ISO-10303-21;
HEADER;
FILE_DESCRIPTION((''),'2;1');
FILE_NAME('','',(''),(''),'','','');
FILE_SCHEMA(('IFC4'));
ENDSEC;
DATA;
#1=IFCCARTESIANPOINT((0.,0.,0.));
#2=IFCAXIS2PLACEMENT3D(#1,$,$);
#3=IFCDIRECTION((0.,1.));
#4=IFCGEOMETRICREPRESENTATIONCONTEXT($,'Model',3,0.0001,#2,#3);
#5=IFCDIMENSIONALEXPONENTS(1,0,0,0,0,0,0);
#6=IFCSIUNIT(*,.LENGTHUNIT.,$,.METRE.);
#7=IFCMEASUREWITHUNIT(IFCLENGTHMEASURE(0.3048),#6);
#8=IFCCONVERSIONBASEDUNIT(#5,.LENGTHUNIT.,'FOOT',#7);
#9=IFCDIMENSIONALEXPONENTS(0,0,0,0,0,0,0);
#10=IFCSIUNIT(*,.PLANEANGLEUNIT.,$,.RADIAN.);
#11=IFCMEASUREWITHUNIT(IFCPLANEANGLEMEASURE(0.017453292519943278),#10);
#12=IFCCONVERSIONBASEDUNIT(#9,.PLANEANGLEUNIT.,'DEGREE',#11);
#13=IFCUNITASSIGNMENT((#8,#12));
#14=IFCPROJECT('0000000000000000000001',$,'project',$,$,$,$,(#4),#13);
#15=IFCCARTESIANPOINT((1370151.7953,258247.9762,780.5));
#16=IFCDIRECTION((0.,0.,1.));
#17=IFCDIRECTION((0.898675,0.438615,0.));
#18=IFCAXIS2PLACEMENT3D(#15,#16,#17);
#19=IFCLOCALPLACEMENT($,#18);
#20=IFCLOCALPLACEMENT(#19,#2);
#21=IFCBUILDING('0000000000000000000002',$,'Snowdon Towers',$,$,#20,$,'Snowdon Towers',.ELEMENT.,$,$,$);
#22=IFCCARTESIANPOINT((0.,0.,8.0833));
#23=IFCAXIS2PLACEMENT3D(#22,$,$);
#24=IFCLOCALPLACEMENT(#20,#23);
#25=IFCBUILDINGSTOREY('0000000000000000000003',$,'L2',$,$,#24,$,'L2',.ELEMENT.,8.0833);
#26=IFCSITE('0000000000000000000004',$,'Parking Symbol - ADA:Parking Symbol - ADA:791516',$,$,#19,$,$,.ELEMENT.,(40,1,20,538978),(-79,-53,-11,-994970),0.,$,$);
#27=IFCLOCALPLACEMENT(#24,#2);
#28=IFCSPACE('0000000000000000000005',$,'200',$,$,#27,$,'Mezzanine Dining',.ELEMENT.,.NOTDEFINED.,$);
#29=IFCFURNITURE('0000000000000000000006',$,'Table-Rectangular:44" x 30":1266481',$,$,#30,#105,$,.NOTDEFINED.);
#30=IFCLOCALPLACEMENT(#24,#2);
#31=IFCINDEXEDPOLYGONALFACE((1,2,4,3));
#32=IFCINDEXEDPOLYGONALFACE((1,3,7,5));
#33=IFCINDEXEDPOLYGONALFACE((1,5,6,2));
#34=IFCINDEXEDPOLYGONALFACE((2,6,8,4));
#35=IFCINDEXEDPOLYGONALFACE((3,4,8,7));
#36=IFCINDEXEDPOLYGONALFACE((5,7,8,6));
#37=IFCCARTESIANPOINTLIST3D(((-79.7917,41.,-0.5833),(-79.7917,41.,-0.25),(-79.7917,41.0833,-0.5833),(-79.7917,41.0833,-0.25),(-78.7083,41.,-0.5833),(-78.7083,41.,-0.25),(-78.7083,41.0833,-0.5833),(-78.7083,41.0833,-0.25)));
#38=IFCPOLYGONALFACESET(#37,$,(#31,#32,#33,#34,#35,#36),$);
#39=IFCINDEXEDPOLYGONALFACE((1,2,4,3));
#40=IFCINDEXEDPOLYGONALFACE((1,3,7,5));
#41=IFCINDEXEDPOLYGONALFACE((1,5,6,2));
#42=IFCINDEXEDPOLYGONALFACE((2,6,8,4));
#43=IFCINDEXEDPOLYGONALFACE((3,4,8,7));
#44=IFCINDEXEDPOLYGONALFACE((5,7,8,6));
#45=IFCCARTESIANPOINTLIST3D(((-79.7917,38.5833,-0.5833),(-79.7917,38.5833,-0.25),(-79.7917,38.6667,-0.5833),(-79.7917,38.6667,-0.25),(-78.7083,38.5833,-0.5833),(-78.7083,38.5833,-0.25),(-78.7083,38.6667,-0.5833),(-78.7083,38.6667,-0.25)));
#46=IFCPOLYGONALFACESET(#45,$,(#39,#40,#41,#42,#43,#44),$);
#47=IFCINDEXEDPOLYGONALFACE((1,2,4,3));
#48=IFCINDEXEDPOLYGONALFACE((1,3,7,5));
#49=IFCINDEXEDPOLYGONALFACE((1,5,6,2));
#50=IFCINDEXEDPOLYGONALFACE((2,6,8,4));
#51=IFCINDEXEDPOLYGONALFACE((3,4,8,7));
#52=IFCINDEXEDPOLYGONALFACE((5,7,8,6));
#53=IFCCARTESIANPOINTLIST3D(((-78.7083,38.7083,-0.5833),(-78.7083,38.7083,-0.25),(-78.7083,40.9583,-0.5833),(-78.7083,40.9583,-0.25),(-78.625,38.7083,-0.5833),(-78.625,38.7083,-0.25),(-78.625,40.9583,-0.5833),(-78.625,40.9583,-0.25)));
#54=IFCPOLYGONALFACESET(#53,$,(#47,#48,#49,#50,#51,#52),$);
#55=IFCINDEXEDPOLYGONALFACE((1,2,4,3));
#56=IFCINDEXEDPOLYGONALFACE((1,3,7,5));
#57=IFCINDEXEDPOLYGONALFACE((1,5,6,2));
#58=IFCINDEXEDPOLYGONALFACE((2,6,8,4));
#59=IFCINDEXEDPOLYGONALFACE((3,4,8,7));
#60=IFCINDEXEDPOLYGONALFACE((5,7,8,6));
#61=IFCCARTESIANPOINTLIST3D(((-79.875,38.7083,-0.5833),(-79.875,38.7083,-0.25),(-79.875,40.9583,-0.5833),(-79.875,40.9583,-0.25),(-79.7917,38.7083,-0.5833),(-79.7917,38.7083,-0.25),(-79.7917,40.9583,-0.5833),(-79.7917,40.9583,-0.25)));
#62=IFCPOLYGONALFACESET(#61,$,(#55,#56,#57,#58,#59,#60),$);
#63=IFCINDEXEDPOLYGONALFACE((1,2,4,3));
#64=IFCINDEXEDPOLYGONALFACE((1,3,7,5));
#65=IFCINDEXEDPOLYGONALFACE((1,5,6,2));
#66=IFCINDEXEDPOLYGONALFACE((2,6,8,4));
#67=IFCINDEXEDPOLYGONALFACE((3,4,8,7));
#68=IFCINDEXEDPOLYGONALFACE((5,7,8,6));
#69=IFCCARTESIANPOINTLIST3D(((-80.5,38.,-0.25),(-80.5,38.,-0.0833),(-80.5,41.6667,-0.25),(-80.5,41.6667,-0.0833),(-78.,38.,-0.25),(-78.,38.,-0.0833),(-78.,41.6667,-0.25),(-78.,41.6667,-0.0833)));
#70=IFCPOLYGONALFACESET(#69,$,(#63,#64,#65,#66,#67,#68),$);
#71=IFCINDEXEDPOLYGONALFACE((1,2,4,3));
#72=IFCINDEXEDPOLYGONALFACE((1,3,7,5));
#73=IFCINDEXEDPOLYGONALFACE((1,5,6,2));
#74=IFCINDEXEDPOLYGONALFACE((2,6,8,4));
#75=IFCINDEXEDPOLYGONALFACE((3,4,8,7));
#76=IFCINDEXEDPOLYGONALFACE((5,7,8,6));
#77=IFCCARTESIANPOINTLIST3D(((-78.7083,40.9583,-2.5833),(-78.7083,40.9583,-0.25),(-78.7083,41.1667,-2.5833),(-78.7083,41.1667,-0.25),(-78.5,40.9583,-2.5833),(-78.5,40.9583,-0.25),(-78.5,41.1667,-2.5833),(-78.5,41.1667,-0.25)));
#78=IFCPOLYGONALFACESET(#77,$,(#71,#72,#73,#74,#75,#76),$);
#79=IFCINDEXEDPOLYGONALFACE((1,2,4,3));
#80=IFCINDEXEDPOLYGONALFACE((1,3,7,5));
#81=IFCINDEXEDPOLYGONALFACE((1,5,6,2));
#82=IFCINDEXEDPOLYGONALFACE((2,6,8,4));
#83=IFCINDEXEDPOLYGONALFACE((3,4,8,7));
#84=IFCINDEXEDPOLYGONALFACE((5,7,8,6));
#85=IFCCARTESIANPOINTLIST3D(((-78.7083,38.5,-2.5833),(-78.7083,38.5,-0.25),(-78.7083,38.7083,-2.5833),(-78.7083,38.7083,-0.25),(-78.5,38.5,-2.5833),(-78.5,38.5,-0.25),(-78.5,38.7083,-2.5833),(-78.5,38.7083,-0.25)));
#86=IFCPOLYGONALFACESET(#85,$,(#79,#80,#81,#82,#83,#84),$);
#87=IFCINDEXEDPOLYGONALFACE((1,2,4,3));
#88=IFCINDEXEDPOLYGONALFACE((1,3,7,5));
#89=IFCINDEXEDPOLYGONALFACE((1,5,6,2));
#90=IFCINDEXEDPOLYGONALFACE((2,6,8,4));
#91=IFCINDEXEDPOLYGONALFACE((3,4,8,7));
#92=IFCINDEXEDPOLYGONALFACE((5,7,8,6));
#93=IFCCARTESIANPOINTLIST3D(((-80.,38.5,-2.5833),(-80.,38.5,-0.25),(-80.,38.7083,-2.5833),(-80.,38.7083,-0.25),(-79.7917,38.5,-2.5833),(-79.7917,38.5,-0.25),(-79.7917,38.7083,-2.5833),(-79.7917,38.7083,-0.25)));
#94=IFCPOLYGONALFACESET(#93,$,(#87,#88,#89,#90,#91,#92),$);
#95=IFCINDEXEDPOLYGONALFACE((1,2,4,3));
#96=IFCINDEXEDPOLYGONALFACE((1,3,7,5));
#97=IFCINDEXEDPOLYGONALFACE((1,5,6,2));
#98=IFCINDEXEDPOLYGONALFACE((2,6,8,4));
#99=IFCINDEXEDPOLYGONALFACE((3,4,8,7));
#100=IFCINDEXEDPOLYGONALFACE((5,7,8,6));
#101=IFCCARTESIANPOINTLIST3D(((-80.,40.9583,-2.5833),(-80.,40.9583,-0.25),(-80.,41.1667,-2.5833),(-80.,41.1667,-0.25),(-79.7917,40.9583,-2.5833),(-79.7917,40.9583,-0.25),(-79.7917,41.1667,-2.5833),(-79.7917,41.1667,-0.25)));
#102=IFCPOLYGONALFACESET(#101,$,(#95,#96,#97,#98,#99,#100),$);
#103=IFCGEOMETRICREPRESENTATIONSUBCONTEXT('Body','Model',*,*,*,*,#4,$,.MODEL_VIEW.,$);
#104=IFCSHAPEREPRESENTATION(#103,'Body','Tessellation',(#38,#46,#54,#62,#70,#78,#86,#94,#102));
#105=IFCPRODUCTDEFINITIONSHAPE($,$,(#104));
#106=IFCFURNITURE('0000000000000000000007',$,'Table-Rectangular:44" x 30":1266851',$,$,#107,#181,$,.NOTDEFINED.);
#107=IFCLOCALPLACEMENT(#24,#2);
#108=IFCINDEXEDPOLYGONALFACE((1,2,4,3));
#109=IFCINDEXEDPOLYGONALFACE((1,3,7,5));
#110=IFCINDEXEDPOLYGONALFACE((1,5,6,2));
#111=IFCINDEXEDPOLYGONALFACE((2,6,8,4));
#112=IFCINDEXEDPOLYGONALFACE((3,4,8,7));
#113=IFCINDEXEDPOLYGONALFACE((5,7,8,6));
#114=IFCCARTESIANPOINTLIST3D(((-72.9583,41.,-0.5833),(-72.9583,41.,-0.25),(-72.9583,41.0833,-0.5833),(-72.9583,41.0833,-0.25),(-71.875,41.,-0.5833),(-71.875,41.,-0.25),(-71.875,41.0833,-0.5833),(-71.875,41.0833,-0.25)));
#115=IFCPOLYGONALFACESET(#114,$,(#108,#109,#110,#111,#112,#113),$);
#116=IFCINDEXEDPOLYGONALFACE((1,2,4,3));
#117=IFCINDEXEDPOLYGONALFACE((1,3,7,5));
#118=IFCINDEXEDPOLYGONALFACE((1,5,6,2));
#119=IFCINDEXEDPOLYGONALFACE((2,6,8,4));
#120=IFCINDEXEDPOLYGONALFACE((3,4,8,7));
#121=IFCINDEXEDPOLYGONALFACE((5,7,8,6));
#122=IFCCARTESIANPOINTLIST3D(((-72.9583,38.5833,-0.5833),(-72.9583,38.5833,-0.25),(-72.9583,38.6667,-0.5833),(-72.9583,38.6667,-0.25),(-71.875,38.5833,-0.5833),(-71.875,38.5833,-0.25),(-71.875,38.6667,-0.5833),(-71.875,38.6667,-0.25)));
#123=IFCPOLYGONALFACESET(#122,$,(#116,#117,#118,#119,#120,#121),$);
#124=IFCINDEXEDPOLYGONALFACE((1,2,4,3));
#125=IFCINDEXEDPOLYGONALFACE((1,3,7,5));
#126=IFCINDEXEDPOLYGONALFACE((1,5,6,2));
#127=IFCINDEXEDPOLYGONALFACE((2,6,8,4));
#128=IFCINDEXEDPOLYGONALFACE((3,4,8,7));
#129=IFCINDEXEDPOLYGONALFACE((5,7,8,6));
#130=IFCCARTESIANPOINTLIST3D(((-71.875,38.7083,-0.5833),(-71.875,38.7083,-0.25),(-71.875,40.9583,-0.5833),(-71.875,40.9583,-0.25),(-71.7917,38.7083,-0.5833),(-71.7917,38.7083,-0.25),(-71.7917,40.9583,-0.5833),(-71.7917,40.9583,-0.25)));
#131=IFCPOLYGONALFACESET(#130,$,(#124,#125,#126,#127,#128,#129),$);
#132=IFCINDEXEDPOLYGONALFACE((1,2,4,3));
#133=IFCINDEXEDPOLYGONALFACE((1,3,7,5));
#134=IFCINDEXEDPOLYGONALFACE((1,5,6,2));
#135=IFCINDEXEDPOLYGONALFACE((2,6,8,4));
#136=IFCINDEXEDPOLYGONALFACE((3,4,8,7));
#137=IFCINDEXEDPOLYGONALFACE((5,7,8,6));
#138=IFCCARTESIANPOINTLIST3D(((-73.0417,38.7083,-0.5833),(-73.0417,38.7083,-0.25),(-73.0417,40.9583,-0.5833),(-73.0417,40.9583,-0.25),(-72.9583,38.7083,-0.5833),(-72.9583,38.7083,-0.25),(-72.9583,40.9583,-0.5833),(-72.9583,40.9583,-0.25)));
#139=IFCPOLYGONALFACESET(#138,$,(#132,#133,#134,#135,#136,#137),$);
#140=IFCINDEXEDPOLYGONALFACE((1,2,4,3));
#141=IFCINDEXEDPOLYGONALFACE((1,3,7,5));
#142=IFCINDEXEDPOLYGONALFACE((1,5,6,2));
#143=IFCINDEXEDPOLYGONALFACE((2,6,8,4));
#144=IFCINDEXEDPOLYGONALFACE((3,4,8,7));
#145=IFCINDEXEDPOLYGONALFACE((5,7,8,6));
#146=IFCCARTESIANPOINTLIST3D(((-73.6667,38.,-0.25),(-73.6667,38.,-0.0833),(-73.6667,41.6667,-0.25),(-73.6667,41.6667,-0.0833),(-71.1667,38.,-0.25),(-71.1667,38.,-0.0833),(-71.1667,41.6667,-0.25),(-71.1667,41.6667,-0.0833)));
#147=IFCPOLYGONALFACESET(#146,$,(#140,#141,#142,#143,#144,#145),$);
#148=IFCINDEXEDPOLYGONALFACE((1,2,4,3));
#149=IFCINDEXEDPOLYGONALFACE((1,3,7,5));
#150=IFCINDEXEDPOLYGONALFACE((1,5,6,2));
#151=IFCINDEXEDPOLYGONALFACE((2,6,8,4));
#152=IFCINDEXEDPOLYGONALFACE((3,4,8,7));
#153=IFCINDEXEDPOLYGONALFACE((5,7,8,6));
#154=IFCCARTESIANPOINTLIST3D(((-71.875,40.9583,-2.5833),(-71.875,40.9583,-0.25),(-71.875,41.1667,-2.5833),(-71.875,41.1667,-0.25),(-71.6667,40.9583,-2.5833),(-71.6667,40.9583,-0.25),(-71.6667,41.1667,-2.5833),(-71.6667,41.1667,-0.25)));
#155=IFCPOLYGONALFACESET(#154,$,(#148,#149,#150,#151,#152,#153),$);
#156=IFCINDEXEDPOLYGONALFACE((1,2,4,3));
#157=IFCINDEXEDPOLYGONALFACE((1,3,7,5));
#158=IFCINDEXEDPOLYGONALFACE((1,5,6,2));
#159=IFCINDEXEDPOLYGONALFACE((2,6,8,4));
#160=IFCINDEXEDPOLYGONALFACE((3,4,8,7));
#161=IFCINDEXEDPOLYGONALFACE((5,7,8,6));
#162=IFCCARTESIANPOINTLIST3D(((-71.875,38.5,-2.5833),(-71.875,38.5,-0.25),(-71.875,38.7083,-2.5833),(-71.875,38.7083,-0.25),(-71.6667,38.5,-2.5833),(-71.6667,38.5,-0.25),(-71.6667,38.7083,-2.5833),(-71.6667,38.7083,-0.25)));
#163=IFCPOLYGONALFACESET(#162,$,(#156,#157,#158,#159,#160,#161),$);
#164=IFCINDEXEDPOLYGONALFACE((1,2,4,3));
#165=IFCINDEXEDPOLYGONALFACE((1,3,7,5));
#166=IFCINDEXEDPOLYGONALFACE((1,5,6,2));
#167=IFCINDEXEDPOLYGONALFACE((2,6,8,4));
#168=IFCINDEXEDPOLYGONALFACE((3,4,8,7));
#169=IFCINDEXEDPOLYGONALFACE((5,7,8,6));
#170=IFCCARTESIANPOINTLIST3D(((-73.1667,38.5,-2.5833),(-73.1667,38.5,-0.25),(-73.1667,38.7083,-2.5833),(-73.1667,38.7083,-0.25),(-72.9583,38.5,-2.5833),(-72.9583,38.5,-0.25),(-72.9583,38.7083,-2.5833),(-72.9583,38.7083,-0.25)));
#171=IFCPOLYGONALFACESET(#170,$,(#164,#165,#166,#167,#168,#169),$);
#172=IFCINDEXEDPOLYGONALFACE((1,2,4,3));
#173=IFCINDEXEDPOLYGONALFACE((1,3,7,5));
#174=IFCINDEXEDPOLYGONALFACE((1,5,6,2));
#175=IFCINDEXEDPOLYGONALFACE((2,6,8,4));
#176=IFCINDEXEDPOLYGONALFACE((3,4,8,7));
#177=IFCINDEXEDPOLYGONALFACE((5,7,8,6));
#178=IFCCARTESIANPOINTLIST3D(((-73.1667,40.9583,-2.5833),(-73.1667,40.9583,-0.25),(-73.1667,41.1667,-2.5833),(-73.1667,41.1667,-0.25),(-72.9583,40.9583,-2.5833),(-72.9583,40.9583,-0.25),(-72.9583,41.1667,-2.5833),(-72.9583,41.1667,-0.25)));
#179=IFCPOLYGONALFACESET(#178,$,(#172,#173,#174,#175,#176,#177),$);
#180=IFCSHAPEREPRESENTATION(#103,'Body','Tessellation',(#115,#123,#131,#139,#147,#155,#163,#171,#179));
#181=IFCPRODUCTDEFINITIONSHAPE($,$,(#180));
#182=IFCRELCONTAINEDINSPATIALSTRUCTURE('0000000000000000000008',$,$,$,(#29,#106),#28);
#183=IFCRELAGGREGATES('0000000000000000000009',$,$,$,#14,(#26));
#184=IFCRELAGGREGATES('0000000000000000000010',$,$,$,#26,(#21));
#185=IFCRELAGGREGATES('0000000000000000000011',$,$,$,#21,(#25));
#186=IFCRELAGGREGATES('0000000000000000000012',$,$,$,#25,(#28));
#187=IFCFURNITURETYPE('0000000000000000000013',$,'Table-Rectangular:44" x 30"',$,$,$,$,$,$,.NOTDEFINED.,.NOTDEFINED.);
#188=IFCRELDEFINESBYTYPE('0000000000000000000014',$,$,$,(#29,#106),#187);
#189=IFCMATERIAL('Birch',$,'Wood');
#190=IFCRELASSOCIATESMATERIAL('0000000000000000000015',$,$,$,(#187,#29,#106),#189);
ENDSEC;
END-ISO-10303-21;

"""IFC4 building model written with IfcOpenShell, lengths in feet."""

from ifc_helpers import new_model, entity, si_unit, converted_unit, direction, frame, origin, place, context, subcontext, project, spatial, indexed_curve, outline, extrude, source, transform, mapped, material, type_object, type_shapes, element, save


model = new_model("IFC4")

# Units and contexts
model_context = context("Model", 3, precision=0.0001, world=origin(), true_north=direction((0.0, 1.0)))
body_context = subcontext(model_context, "Body", "Model", "MODEL_VIEW")
ifc_project = project(units=[converted_unit("LENGTHUNIT", "FOOT", entity("IfcLengthMeasure", 0.3048), si_unit("LENGTHUNIT", "METRE"), dimensions=[1, 0, 0, 0, 0, 0, 0]), converted_unit("PLANEANGLEUNIT", "DEGREE", entity("IfcPlaneAngleMeasure", 0.017453292519943278), si_unit("PLANEANGLEUNIT", "RADIAN"), dimensions=[0, 0, 0, 0, 0, 0, 0])], contexts=[model_context])

# Site, building, storey
site_placement = place(None, frame((1370151.7953, 258247.9762, 780.5), z_axis=(0.0, 0.0, 1.0), x_axis=(0.898675, 0.438615, 0.0)))
site = spatial("IfcSite", under=ifc_project, at=site_placement, Name="Parking Symbol - ADA:Parking Symbol - ADA:791516", CompositionType="ELEMENT", RefLatitude=(40, 1, 20, 538978), RefLongitude=(-79, -53, -11, -994970), RefElevation=0.0)
building_placement = place(site_placement, origin())
building = spatial("IfcBuilding", under=site, at=building_placement, Name="Snowdon Towers", LongName="Snowdon Towers", CompositionType="ELEMENT")
storey_placement = place(building_placement, frame((0.0, 0.0, 8.0833)))
storey = spatial("IfcBuildingStorey", under=building, at=storey_placement, Name="L2", LongName="L2", CompositionType="ELEMENT", Elevation=8.0833)

# Shared definitions
space_1_placement = place(storey_placement, origin())
space_1 = spatial("IfcSpace", under=storey, at=space_1_placement, Name="200", LongName="Mezzanine Dining", CompositionType="ELEMENT", PredefinedType="NOTDEFINED")

# Furniture
ifc_material_1 = material(Name="Birch", Category="Wood")
furniture_type_1 = type_object("IfcFurnitureType", Name="Table-Rectangular:44\" x 30\"", AssemblyPlace="NOTDEFINED", PredefinedType="NOTDEFINED", material=ifc_material_1)
shared_shape_1 = source(origin(), body_context, "Body", "SweptSolid", [
    extrude(outline(indexed_curve([(-0.5417, -0.0417), (0.5417, -0.0417), (0.5417, 0.0417), (-0.5417, 0.0417), (-0.5417, -0.0417)], self_intersect=False)), frame((1.2083, 0.0, 2.0), z_axis=(0.0, 0.0, 1.0), x_axis=(0.0, -1.0, 0.0)), (0.0, 0.0, 1.0), 0.3333),
    extrude(outline(indexed_curve([(-0.0417, -0.5417), (0.0417, -0.5417), (0.0417, 0.5417), (-0.0417, 0.5417), (-0.0417, -0.5417)], self_intersect=False)), frame((-1.2083, 0.0, 2.0), z_axis=(0.0, 0.0, 1.0), x_axis=(-1.0, 0.0, 0.0)), (0.0, 0.0, 1.0), 0.3333),
    extrude(outline(indexed_curve([(-0.0417, -1.125), (0.0417, -1.125), (0.0417, 1.125), (-0.0417, 1.125), (-0.0417, -1.125)], self_intersect=False)), frame((0.0, -0.5833, 2.0), z_axis=(0.0, 0.0, 1.0), x_axis=(0.0, 1.0, 0.0)), (0.0, 0.0, 1.0), 0.3333),
    extrude(outline(indexed_curve([(-1.125, -0.0417), (1.125, -0.0417), (1.125, 0.0417), (-1.125, 0.0417), (-1.125, -0.0417)], self_intersect=False)), frame((0.0, 0.5833, 2.0), z_axis=(0.0, 0.0, 1.0), x_axis=(-1.0, 0.0, 0.0)), (0.0, 0.0, 1.0), 0.3333),
    extrude(outline(indexed_curve([(-1.25, -1.8333), (1.25, -1.8333), (1.25, 1.8333), (-1.25, 1.8333), (-1.25, -1.8333)], self_intersect=False)), frame((0.0, 0.0, 2.3333), z_axis=(0.0, 0.0, 1.0), x_axis=(0.0, 1.0, 0.0)), (0.0, 0.0, 1.0), 0.1667),
    extrude(outline(indexed_curve([(-0.1042, -0.1042), (0.1042, -0.1042), (0.1042, 0.1042), (-0.1042, 0.1042), (-0.1042, -0.1042)], self_intersect=False)), frame((1.2292, -0.6458, 0.0)), (0.0, 0.0, 1.0), 2.3333),
    extrude(outline(indexed_curve([(-0.1042, -0.1042), (0.1042, -0.1042), (0.1042, 0.1042), (-0.1042, 0.1042), (-0.1042, -0.1042)], self_intersect=False)), frame((-1.2292, -0.6458, 0.0), z_axis=(0.0, 0.0, 1.0), x_axis=(0.0, 1.0, 0.0)), (0.0, 0.0, 1.0), 2.3333),
    extrude(outline(indexed_curve([(-0.1042, -0.1042), (0.1042, -0.1042), (0.1042, 0.1042), (-0.1042, 0.1042), (-0.1042, -0.1042)], self_intersect=False)), frame((-1.2292, 0.6458, 0.0), z_axis=(0.0, 0.0, 1.0), x_axis=(-1.0, 0.0, 0.0)), (0.0, 0.0, 1.0), 2.3333),
    extrude(outline(indexed_curve([(-0.1042, -0.1042), (0.1042, -0.1042), (0.1042, 0.1042), (-0.1042, 0.1042), (-0.1042, -0.1042)], self_intersect=False)), frame((1.2292, 0.6458, 0.0), z_axis=(0.0, 0.0, 1.0), x_axis=(0.0, -1.0, 0.0)), (0.0, 0.0, 1.0), 2.3333),
])
type_shapes(furniture_type_1, [shared_shape_1])
for number, where, z_axis, x_axis, name in (
    (1, (-79.25, 39.8333, -2.5833), (0.0, 0.0, 1.0), (0.0, 1.0, 0.0), "Table-Rectangular:44\" x 30\":1266481"),
    (2, (-72.4167, 39.8333, -2.5833), (0.0, 0.0, 1.0), (0.0, 1.0, 0.0), "Table-Rectangular:44\" x 30\":1266851"),
):
    element("IfcFurniture", number, at=place(space_1_placement, frame(where, z_axis=z_axis, x_axis=x_axis)), inside=space_1, type_object=furniture_type_1, material=ifc_material_1, Name=name, PredefinedType="NOTDEFINED", context=body_context, shape_type="MappedRepresentation", body=[
        mapped(shared_shape_1, transform((0.0, 0.0, 0.0), scale=1.0)),
    ])

save(model, "model.ifc")
